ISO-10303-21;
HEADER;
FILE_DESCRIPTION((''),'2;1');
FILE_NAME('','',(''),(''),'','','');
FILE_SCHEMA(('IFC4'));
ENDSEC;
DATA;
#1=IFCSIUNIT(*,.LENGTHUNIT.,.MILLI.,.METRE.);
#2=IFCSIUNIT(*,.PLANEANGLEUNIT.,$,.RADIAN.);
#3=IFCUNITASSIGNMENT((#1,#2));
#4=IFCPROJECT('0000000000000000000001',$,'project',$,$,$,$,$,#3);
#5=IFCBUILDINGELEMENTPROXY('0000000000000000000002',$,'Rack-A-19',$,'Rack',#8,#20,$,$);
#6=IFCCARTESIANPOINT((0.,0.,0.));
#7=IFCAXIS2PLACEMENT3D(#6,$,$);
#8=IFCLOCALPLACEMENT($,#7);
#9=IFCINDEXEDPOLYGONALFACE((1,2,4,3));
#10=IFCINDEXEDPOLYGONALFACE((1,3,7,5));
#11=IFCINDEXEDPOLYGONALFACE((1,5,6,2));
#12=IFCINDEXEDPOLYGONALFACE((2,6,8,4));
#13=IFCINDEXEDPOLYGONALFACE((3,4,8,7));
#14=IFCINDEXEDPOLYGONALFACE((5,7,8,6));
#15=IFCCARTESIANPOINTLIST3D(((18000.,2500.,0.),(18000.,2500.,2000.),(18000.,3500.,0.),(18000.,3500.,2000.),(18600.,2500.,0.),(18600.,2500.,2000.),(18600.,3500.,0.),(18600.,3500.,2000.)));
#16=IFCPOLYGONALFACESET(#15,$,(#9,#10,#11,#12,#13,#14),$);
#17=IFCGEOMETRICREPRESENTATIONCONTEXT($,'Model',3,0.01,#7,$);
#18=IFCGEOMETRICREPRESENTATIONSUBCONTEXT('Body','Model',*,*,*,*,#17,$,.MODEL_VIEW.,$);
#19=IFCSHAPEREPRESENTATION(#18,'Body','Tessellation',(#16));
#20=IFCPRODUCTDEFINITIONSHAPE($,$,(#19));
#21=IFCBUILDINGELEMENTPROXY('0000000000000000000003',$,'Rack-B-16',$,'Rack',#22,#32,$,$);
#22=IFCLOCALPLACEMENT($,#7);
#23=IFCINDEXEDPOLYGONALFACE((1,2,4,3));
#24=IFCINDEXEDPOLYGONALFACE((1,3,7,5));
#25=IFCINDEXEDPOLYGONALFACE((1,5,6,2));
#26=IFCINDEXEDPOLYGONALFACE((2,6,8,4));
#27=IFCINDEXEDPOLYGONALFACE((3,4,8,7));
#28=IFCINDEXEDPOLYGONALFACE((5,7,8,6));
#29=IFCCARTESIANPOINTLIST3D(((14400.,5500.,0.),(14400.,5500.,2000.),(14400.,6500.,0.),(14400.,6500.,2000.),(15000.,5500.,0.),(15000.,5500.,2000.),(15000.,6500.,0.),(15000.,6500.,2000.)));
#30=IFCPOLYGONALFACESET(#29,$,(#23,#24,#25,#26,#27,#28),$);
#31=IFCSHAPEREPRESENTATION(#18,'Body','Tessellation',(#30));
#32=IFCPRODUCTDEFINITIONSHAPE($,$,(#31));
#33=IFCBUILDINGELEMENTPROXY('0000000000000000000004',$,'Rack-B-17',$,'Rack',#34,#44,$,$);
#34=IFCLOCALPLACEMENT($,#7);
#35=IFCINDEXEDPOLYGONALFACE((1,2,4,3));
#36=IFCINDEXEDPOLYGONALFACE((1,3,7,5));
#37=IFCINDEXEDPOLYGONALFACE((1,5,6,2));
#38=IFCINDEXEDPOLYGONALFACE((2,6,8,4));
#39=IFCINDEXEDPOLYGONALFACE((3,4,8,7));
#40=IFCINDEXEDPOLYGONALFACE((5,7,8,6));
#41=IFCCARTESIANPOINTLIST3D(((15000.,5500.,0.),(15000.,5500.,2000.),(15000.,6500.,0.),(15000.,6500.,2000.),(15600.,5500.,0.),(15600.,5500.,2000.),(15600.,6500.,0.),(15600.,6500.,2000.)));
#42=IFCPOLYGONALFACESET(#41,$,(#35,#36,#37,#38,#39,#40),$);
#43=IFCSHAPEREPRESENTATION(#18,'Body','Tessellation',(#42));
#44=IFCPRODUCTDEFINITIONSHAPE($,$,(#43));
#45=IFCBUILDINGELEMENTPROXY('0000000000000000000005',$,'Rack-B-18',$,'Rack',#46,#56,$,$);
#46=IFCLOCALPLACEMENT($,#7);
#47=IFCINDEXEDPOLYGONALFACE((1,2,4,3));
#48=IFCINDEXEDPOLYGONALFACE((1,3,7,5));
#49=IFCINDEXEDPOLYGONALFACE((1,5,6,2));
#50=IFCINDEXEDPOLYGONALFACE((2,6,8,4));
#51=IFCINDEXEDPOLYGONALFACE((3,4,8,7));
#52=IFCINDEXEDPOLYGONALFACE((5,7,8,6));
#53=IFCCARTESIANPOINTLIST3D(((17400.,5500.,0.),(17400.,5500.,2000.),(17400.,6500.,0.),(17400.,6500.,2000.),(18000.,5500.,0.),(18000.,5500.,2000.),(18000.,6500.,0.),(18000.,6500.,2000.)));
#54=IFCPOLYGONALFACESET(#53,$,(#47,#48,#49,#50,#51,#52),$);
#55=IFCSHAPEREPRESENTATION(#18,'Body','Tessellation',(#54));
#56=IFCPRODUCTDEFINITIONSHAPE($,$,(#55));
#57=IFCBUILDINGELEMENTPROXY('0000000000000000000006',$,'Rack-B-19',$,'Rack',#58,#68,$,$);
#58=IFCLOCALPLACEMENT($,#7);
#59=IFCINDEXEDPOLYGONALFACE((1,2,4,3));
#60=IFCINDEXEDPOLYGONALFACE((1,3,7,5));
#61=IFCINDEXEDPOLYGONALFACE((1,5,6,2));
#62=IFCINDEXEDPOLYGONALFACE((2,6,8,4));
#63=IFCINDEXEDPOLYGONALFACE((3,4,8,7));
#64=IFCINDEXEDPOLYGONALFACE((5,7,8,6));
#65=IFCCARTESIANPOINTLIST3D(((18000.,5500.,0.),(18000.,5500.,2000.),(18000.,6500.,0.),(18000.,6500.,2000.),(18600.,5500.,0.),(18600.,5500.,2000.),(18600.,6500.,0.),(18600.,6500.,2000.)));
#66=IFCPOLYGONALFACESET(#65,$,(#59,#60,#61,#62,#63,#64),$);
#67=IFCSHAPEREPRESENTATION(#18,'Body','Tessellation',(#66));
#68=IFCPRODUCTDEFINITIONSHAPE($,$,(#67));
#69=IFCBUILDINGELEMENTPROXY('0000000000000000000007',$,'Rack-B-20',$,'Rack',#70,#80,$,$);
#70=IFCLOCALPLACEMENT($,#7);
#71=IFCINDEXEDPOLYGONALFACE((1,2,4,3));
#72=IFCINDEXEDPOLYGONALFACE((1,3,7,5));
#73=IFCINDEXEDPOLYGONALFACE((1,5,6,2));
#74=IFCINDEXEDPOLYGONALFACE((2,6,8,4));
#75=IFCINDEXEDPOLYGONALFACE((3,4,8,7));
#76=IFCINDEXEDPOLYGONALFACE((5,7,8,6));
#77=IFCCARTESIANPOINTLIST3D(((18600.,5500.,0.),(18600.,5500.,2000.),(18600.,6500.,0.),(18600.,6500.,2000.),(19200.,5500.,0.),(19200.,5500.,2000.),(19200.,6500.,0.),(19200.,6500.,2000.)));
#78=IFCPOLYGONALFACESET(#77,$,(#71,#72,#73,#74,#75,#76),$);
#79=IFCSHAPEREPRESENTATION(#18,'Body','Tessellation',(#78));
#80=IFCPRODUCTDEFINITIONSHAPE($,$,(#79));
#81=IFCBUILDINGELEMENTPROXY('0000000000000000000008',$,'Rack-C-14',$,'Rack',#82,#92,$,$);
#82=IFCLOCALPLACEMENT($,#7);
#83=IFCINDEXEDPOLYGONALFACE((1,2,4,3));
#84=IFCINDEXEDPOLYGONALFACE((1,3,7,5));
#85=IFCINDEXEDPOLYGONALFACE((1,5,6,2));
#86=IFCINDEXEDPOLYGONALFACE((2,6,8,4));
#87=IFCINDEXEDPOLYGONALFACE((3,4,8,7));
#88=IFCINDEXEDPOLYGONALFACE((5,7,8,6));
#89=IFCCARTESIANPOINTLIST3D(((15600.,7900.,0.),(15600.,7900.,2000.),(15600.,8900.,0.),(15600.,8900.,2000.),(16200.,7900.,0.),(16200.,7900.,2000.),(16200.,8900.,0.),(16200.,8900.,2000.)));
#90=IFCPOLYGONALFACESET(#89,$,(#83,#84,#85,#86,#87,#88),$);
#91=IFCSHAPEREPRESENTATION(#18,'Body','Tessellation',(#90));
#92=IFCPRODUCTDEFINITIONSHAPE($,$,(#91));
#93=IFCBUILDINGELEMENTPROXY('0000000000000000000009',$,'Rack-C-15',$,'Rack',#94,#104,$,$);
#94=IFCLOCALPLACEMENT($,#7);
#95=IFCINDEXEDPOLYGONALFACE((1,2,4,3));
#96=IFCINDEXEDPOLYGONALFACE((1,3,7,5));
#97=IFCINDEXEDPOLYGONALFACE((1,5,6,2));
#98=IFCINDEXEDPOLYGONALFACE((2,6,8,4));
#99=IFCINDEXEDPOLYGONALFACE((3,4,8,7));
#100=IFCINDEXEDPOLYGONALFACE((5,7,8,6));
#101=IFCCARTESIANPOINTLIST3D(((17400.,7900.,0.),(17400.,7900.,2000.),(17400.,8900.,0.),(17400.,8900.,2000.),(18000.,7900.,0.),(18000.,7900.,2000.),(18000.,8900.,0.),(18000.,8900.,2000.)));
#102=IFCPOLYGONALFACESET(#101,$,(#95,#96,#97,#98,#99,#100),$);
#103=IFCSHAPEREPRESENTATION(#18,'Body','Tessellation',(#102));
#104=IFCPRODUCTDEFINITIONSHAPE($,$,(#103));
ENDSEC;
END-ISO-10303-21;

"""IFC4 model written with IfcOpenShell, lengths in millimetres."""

from ifc_helpers import new_model, si_unit, frame, origin, place, context, subcontext, project, rectangle, extrude, element, save


model = new_model("IFC4")

# Units and contexts
model_context = context("Model", 3, precision=0.01, world=origin())
body_context = subcontext(model_context, "Body", "Model", "MODEL_VIEW")
ifc_project = project(units=[si_unit("LENGTHUNIT", "METRE", prefix="MILLI"), si_unit("PLANEANGLEUNIT", "RADIAN")])

# Shared definitions
placement = place(None, origin())

# Building element proxies
for number, where, name in (
    (1, (18300.0, 3000.0, 0.0), "Rack-A-19"),
    (2, (14700.0, 6000.0, 0.0), "Rack-B-16"),
    (3, (15300.0, 6000.0, 0.0), "Rack-B-17"),
    (4, (17700.0, 6000.0, 0.0), "Rack-B-18"),
    (5, (18300.0, 6000.0, 0.0), "Rack-B-19"),
    (6, (18900.0, 6000.0, 0.0), "Rack-B-20"),
    (7, (15900.0, 8400.0, 0.0), "Rack-C-14"),
    (8, (17700.0, 8400.0, 0.0), "Rack-C-15"),
):
    element("IfcBuildingElementProxy", number, at=place(placement, frame(where)), Name=name, ObjectType="Rack", context=body_context, shape_type="SweptSolid", body=[
        extrude(rectangle(XDim=600.0, YDim=1000.0), origin(), (0.0, 0.0, 1.0), 2000.0),
    ])

save(model, "model.ifc")
